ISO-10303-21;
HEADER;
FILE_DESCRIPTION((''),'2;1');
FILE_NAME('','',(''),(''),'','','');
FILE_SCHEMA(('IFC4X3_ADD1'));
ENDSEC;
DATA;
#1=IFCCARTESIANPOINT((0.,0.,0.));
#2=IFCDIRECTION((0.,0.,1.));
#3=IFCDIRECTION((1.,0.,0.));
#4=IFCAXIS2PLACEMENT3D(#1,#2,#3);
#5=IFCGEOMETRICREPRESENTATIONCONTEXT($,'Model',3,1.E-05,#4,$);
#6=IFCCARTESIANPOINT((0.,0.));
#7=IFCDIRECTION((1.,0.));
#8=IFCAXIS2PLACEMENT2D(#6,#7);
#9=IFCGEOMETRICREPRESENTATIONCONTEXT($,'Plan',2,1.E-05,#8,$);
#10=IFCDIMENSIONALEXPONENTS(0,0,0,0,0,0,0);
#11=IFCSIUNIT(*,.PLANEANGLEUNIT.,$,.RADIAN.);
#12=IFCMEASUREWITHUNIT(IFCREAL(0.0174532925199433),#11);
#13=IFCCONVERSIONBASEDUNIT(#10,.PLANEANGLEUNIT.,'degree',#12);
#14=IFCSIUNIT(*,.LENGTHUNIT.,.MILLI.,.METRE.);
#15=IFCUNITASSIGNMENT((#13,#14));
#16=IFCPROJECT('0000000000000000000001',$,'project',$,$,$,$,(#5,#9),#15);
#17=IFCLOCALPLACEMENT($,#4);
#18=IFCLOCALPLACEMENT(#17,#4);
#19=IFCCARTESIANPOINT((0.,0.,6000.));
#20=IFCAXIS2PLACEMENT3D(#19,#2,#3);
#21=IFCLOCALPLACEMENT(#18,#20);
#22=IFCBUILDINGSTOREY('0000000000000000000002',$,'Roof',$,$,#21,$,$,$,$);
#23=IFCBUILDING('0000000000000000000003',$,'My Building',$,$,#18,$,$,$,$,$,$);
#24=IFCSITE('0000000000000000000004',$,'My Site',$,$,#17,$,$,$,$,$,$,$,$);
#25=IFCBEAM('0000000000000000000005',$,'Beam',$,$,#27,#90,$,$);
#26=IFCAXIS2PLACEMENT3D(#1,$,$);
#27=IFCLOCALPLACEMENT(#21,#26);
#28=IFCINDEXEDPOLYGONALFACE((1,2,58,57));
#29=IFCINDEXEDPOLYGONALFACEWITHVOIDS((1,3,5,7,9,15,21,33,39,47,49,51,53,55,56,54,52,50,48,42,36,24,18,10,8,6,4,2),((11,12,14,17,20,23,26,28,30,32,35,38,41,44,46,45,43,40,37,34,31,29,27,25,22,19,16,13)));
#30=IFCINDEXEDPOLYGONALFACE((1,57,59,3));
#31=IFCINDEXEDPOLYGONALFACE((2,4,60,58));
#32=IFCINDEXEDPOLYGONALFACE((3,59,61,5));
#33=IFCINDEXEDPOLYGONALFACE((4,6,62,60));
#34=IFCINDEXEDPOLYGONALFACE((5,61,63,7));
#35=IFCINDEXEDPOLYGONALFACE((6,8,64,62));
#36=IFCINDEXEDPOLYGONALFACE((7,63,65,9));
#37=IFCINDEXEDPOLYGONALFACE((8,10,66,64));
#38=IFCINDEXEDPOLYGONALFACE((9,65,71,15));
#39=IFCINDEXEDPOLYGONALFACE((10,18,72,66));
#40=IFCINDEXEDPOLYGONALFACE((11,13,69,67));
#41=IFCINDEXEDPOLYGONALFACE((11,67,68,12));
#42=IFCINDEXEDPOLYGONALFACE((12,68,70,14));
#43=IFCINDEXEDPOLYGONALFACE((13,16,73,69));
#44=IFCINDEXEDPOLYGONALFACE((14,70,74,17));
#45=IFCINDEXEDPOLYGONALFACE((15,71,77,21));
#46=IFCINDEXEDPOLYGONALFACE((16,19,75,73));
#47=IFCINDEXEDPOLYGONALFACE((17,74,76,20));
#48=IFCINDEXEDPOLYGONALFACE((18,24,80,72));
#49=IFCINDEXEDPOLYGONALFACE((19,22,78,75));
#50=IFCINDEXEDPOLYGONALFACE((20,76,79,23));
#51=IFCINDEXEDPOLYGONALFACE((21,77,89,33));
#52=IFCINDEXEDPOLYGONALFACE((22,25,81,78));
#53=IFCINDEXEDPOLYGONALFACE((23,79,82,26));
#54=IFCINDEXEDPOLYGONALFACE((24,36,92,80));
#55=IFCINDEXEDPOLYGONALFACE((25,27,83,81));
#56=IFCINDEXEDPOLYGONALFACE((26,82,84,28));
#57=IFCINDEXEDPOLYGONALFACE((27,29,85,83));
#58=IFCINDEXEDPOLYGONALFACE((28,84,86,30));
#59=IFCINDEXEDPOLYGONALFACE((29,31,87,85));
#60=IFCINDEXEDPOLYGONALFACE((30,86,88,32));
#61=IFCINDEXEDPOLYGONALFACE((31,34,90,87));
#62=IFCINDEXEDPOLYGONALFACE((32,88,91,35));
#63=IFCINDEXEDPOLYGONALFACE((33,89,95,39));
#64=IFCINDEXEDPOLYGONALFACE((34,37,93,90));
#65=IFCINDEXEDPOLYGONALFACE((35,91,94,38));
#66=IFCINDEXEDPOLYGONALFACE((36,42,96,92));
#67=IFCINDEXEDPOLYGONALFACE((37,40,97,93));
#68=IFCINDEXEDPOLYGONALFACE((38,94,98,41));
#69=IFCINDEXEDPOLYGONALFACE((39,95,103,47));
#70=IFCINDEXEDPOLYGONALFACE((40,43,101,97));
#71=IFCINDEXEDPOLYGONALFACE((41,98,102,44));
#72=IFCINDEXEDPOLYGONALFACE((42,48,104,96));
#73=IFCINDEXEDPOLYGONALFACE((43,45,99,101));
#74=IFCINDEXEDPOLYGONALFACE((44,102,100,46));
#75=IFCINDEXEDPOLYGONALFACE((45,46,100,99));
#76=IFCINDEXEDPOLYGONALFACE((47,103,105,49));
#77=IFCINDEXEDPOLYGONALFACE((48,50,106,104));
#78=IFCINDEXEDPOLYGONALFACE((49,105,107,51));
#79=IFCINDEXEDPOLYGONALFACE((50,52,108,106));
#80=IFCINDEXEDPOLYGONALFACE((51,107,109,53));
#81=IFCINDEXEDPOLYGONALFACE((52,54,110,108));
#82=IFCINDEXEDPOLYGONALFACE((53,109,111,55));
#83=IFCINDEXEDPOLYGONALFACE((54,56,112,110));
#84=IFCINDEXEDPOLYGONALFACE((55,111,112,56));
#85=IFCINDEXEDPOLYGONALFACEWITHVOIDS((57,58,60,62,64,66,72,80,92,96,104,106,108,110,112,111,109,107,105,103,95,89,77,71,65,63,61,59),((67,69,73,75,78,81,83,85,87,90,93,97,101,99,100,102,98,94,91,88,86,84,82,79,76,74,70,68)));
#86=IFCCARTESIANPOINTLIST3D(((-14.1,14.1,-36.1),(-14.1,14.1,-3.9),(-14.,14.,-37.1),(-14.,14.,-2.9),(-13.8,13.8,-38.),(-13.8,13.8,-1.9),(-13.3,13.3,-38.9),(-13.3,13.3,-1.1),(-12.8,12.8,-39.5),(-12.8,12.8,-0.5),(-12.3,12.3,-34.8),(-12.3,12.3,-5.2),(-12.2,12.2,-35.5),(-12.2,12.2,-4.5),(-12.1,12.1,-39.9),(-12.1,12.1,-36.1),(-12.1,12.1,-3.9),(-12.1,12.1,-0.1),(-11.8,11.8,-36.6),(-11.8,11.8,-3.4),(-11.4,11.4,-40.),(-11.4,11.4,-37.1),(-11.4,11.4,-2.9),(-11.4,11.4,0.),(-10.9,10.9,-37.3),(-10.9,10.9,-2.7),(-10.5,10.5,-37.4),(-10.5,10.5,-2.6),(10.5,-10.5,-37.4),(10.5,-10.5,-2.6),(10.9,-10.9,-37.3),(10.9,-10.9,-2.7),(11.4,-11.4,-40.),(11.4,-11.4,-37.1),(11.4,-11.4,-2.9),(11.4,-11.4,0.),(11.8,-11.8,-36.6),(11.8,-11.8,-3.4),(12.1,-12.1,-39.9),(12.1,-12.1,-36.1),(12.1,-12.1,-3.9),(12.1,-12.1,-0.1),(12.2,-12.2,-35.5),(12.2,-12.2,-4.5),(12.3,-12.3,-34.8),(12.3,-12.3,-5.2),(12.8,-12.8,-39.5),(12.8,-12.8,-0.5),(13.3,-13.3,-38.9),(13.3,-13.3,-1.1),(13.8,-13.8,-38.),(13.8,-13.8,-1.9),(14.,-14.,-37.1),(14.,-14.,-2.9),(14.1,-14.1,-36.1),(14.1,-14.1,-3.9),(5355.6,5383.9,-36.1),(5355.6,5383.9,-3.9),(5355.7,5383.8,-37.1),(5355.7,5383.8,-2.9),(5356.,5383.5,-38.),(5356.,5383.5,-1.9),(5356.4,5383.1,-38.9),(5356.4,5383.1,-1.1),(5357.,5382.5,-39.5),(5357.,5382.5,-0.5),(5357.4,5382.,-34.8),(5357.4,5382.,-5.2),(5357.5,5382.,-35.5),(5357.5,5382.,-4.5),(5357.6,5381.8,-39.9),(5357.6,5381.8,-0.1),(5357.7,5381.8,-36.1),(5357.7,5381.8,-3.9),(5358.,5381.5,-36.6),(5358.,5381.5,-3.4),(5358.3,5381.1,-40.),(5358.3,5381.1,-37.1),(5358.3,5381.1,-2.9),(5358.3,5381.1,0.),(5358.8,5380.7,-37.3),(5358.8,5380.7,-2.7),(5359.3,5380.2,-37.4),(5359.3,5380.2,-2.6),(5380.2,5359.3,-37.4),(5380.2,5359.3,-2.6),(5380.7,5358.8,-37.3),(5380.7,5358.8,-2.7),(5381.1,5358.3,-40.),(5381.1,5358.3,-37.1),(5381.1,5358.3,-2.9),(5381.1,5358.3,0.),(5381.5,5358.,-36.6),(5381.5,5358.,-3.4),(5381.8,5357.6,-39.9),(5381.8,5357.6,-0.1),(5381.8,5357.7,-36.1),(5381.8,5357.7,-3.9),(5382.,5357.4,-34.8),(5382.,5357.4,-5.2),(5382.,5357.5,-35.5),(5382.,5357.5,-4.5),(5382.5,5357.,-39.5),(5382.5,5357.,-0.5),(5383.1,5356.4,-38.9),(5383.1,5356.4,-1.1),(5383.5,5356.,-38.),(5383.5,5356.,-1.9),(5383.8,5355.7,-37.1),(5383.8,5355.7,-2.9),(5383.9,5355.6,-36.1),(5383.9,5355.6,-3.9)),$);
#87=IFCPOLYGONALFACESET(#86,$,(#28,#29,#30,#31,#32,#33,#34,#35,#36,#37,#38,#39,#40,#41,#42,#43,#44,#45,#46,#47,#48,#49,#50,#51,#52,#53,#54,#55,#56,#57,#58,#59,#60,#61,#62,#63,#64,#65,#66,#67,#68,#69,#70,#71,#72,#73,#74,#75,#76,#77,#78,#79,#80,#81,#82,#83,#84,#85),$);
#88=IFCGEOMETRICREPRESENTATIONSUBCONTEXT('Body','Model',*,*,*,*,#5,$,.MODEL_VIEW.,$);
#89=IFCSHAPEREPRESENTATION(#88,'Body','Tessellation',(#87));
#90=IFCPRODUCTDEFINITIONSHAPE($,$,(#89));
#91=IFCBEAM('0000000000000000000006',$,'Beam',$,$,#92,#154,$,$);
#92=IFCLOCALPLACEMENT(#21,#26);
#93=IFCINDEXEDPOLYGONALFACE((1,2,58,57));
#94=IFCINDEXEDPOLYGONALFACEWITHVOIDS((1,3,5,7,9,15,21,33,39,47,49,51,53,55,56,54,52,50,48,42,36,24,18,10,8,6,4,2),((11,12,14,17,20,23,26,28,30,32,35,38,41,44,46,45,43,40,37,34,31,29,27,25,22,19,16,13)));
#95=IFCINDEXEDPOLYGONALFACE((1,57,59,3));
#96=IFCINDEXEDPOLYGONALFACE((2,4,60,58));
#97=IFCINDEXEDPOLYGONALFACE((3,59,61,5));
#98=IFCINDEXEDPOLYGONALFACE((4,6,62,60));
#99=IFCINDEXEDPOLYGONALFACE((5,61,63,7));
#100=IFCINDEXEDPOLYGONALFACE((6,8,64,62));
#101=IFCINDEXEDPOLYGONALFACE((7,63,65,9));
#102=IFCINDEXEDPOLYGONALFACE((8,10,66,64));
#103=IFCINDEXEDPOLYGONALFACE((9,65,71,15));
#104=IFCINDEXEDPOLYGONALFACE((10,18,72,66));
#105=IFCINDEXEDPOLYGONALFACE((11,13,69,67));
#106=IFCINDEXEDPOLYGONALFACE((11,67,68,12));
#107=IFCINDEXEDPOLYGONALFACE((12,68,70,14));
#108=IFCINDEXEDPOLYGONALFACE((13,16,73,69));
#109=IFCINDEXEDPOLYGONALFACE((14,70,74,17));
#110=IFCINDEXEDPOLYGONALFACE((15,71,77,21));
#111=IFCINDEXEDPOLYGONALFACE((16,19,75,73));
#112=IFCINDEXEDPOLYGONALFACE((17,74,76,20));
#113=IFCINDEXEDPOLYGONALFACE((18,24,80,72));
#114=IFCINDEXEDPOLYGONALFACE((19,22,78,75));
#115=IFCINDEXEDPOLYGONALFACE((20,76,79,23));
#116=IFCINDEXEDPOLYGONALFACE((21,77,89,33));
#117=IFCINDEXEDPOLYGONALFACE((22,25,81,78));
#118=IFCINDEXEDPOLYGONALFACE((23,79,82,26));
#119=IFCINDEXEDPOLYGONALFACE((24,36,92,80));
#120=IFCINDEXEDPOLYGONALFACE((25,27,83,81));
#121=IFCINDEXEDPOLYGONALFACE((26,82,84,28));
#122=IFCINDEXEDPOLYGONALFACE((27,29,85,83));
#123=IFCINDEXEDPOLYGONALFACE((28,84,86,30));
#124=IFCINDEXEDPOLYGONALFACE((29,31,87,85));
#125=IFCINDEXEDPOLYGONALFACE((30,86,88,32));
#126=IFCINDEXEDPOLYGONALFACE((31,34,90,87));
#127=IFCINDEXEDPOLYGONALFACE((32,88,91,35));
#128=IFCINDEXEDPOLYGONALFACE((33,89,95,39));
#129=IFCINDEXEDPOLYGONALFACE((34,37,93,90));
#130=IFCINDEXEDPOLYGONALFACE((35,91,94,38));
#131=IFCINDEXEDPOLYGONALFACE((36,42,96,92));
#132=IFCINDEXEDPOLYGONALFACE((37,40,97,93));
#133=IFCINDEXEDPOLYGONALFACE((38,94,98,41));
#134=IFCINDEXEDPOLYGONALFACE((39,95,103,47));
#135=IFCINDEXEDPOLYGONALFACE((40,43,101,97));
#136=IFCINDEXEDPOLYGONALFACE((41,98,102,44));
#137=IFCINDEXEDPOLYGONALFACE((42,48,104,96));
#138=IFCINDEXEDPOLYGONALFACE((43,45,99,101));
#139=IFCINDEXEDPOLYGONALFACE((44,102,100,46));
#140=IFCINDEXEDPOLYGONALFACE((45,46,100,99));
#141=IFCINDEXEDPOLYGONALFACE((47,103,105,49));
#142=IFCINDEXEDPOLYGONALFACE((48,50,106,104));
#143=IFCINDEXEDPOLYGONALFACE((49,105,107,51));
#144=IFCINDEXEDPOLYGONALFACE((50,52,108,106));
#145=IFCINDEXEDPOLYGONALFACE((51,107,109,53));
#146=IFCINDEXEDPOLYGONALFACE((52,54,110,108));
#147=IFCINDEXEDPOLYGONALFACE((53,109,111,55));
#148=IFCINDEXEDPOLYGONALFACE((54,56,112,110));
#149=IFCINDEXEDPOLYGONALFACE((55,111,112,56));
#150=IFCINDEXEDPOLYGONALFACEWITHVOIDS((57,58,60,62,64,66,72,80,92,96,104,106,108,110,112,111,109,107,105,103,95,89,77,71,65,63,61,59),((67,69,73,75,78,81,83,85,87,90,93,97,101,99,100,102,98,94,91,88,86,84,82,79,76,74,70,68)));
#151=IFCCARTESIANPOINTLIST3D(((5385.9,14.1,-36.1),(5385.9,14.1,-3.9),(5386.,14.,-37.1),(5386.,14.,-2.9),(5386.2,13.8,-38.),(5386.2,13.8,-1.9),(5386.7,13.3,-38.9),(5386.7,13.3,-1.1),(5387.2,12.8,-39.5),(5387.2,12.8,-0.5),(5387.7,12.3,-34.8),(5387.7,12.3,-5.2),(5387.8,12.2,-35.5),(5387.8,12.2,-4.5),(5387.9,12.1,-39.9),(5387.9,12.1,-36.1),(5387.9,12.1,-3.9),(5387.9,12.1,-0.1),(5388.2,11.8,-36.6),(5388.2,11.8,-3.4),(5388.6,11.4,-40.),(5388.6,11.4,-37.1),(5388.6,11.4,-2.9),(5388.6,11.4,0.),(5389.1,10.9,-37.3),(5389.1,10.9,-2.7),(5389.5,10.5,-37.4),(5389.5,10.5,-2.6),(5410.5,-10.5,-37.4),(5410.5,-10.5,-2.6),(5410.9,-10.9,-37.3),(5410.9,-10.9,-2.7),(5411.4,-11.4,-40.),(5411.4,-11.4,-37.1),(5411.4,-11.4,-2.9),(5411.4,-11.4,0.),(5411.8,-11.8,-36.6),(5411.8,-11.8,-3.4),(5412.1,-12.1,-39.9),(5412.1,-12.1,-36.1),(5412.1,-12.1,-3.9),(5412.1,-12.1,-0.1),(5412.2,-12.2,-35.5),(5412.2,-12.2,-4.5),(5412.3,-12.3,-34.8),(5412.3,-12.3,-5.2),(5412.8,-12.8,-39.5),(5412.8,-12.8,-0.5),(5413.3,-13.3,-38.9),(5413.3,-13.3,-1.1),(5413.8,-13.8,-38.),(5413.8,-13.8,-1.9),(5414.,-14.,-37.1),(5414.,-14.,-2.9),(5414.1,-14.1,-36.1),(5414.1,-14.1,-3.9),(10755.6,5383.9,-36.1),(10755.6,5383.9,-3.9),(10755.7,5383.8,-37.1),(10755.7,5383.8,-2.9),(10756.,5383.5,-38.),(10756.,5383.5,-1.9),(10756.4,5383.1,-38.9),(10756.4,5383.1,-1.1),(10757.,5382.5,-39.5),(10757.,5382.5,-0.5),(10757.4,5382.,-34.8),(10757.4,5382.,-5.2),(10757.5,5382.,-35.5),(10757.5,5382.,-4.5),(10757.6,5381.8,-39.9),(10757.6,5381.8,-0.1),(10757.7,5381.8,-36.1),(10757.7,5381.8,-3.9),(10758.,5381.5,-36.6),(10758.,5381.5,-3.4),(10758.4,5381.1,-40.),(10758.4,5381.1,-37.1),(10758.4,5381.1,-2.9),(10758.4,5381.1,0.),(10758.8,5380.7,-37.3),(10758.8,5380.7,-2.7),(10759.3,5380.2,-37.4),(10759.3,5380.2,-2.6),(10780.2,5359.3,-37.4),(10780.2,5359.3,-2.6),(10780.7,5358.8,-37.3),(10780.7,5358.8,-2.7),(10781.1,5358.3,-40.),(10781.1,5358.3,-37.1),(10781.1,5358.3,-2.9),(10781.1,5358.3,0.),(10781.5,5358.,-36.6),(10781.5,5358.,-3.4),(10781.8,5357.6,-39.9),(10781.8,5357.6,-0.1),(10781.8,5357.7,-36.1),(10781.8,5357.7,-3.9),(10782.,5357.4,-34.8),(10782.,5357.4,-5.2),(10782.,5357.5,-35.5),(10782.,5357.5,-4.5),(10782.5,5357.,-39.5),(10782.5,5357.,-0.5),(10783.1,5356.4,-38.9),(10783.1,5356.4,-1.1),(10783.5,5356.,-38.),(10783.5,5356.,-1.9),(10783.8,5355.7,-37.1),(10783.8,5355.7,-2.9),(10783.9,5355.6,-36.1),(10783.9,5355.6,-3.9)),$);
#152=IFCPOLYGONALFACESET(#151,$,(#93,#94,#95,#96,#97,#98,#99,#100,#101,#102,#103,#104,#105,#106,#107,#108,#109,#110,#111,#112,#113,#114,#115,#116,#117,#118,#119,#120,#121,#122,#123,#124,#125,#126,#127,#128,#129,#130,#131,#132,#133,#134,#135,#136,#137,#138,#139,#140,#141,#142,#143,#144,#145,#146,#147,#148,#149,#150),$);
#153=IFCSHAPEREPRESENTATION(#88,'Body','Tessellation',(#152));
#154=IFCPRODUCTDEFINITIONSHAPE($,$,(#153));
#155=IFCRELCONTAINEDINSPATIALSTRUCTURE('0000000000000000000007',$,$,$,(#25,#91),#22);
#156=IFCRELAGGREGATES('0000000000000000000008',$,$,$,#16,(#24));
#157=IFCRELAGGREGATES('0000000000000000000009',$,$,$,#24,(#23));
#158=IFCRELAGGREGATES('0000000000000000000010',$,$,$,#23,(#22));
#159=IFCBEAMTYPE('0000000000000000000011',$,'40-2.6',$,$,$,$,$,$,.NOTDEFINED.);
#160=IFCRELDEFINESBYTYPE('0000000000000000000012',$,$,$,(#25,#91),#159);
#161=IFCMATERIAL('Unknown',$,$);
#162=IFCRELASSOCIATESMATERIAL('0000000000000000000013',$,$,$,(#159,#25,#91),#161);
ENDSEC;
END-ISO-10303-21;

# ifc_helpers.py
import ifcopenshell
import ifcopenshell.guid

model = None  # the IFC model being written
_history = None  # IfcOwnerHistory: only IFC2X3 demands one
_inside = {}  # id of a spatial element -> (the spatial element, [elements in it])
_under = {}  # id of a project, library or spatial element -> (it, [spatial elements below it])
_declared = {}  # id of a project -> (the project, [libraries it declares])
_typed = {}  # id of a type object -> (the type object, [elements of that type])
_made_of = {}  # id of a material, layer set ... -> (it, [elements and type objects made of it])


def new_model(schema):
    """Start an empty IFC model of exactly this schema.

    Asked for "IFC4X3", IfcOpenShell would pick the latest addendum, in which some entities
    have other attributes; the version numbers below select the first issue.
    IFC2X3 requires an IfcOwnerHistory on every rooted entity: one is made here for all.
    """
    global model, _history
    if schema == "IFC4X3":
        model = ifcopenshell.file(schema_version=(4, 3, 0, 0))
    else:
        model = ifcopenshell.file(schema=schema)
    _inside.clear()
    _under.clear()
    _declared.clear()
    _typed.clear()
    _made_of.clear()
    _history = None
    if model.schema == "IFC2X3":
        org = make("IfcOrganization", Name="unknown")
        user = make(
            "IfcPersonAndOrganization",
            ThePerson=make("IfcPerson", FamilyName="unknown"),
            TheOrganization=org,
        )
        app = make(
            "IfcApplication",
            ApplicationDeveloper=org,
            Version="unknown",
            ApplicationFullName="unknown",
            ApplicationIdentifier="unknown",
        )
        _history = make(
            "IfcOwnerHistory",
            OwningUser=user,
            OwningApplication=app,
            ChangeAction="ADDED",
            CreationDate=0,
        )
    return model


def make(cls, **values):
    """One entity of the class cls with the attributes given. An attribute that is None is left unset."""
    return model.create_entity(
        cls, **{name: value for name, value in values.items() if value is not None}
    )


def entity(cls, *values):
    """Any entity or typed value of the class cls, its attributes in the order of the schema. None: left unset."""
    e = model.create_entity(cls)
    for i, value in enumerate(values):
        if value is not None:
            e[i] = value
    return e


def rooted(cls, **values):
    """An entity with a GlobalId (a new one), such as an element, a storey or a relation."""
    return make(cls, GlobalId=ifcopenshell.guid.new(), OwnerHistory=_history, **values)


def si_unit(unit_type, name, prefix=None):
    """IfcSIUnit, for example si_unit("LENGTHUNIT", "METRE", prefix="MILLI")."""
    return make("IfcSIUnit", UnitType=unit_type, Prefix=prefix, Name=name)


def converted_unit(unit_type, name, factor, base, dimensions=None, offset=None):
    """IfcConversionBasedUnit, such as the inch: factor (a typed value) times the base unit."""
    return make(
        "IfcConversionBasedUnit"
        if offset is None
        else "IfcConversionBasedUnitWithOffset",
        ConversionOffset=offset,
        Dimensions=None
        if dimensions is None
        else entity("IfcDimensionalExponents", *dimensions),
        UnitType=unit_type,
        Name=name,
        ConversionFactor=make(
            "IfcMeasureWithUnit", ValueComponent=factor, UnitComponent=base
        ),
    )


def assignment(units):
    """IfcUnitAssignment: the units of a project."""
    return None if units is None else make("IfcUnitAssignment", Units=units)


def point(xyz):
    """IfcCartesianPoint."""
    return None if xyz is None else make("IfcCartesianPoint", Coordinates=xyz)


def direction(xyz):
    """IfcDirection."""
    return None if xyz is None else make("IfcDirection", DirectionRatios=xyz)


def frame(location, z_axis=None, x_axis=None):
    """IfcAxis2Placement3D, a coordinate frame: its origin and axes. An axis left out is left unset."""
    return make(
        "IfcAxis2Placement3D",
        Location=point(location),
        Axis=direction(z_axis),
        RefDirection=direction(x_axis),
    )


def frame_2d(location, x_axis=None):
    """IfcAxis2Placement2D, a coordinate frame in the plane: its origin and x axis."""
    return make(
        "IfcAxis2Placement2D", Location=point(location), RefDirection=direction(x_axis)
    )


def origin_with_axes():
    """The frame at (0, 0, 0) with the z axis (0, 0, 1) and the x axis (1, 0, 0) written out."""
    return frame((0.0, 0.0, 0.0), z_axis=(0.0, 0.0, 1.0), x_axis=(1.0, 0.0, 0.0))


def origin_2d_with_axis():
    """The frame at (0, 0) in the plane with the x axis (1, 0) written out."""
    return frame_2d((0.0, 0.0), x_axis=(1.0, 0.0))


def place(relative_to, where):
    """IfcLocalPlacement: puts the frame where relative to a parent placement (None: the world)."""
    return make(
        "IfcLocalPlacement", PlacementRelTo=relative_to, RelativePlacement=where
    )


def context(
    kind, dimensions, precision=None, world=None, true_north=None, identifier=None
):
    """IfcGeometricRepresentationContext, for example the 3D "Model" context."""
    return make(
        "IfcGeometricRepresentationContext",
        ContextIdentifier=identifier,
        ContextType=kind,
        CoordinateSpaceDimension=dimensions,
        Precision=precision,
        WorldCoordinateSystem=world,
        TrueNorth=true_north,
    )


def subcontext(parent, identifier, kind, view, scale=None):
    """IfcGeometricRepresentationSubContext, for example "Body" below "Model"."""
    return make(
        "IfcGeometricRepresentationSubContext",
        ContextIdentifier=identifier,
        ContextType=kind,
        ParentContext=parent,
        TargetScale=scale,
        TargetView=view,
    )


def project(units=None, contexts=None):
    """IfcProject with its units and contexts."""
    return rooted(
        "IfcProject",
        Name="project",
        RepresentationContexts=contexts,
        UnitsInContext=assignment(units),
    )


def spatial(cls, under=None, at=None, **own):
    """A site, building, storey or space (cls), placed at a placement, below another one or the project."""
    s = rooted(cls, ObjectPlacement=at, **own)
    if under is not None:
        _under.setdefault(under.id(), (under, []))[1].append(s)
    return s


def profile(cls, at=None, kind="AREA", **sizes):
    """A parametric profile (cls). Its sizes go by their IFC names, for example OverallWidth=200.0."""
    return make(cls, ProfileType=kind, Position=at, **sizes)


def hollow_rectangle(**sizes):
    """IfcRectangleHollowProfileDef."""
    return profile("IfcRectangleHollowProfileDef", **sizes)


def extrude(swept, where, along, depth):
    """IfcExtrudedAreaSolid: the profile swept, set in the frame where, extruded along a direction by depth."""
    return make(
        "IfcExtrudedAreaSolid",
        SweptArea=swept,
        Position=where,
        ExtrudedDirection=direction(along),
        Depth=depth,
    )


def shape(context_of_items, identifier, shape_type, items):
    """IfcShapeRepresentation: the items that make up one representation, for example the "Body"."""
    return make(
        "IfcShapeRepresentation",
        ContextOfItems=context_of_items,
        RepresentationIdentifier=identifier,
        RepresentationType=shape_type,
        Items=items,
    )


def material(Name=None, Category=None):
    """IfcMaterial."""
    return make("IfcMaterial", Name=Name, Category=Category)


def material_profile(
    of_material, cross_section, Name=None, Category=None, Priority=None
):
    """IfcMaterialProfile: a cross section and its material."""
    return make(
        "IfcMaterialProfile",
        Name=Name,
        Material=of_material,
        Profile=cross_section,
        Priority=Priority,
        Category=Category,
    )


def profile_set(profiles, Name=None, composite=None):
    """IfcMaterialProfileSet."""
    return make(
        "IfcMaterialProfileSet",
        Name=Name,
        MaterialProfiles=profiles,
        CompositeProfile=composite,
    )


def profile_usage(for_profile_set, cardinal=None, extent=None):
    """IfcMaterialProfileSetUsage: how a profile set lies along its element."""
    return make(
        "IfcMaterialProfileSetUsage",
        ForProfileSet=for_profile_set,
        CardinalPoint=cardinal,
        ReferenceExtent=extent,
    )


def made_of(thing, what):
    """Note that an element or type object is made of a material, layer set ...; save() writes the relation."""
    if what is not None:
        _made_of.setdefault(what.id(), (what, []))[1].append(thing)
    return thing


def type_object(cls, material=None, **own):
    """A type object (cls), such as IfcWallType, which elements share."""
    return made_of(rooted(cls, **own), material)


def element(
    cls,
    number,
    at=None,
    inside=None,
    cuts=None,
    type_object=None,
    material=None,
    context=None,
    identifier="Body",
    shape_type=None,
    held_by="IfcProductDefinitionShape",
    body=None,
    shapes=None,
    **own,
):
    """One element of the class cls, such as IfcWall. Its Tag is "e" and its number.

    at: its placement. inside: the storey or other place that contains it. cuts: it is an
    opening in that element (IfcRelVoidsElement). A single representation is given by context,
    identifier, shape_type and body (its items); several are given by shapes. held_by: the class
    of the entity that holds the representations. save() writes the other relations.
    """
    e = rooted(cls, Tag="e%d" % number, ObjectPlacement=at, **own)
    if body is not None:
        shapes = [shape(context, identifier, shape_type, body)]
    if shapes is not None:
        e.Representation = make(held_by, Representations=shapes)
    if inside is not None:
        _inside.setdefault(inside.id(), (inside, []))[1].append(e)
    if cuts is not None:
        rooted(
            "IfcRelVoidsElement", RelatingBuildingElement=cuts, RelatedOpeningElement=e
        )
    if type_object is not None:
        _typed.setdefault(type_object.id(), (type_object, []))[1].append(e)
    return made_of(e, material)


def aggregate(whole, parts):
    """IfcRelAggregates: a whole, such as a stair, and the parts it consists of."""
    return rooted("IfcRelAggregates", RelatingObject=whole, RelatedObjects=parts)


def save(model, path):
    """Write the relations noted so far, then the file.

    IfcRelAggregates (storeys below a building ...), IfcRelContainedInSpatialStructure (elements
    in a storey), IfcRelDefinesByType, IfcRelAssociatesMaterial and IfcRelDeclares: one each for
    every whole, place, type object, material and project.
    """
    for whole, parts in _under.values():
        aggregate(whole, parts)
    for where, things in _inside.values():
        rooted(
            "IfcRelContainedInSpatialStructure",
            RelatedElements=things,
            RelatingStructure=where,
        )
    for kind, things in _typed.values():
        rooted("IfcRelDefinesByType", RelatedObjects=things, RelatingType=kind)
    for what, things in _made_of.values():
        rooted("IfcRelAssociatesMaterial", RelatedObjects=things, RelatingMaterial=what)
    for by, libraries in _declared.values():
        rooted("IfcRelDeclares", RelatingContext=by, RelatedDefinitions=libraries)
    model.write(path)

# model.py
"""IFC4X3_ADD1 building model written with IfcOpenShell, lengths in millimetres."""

from ifc_helpers import new_model, entity, si_unit, converted_unit, frame, origin_with_axes, origin_2d_with_axis, place, context, subcontext, project, spatial, hollow_rectangle, extrude, material, material_profile, profile_set, profile_usage, type_object, element, save


model = new_model("IFC4X3_ADD1")

# Units and contexts
model_context = context("Model", 3, precision=1e-05, world=origin_with_axes())
plan_context = context("Plan", 2, precision=1e-05, world=origin_2d_with_axis())
body_context = subcontext(model_context, "Body", "Model", "MODEL_VIEW")
ifc_project = project(units=[converted_unit("PLANEANGLEUNIT", "degree", entity("IfcReal", 0.0174532925199433), si_unit("PLANEANGLEUNIT", "RADIAN"), dimensions=[0, 0, 0, 0, 0, 0, 0]), si_unit("LENGTHUNIT", "METRE", prefix="MILLI")], contexts=[model_context, plan_context])

# Site, building, storey
site_placement = place(None, origin_with_axes())
site = spatial("IfcSite", under=ifc_project, at=site_placement, Name="My Site")
building_placement = place(site_placement, origin_with_axes())
building = spatial("IfcBuilding", under=site, at=building_placement, Name="My Building")
storey_placement = place(building_placement, frame((0.0, 0.0, 6000.0), z_axis=(0.0, 0.0, 1.0), x_axis=(1.0, 0.0, 0.0)))
storey = spatial("IfcBuildingStorey", under=building, at=storey_placement, Name="Roof")

# Beams
ifc_material = material(Name="Unknown")
ifc_material_profile_1 = material_profile(ifc_material, hollow_rectangle(XDim=40.0, YDim=40.0, WallThickness=2.6, InnerFilletRadius=2.6, OuterFilletRadius=3.9))
ifc_profile_set_1 = profile_set([ifc_material_profile_1])
beam_type_1 = type_object("IfcBeamType", Name="40-2.6", PredefinedType="NOTDEFINED", material=ifc_profile_set_1)
ifc_profile_usage_1 = profile_usage(ifc_profile_set_1, cardinal=8)
beam_1_placement = place(storey_placement, frame((0.0, 0.0, 0.0), z_axis=(0.707107, 0.707107, 0.0), x_axis=(-0.707107, 0.707107, 0.0)))
element("IfcBeam", 1, at=beam_1_placement, inside=storey, type_object=beam_type_1, material=ifc_profile_usage_1, Name="Beam", context=body_context, shape_type="SweptSolid", body=[
    extrude(hollow_rectangle(XDim=40.0, YDim=40.0, WallThickness=2.6, InnerFilletRadius=2.6, OuterFilletRadius=3.9), frame((0.0, -20.0, 0.0), z_axis=(0.0, 0.0, 1.0), x_axis=(1.0, 0.0, 0.0)), (0.0, 0.0, 1.0), 7594.0),
])
ifc_profile_usage_2 = profile_usage(ifc_profile_set_1, cardinal=8)
beam_2_placement = place(storey_placement, frame((5400.0, 0.0, 0.0), z_axis=(0.707107, 0.707107, 0.0), x_axis=(-0.707107, 0.707107, 0.0)))
element("IfcBeam", 2, at=beam_2_placement, inside=storey, type_object=beam_type_1, material=ifc_profile_usage_2, Name="Beam", context=body_context, shape_type="SweptSolid", body=[
    extrude(hollow_rectangle(XDim=40.0, YDim=40.0, WallThickness=2.6, InnerFilletRadius=2.6, OuterFilletRadius=3.9), frame((0.0, -20.0, 0.0), z_axis=(0.0, 0.0, 1.0), x_axis=(1.0, 0.0, 0.0)), (0.0, 0.0, 1.0), 7594.0),
])

save(model, "model.ifc")
